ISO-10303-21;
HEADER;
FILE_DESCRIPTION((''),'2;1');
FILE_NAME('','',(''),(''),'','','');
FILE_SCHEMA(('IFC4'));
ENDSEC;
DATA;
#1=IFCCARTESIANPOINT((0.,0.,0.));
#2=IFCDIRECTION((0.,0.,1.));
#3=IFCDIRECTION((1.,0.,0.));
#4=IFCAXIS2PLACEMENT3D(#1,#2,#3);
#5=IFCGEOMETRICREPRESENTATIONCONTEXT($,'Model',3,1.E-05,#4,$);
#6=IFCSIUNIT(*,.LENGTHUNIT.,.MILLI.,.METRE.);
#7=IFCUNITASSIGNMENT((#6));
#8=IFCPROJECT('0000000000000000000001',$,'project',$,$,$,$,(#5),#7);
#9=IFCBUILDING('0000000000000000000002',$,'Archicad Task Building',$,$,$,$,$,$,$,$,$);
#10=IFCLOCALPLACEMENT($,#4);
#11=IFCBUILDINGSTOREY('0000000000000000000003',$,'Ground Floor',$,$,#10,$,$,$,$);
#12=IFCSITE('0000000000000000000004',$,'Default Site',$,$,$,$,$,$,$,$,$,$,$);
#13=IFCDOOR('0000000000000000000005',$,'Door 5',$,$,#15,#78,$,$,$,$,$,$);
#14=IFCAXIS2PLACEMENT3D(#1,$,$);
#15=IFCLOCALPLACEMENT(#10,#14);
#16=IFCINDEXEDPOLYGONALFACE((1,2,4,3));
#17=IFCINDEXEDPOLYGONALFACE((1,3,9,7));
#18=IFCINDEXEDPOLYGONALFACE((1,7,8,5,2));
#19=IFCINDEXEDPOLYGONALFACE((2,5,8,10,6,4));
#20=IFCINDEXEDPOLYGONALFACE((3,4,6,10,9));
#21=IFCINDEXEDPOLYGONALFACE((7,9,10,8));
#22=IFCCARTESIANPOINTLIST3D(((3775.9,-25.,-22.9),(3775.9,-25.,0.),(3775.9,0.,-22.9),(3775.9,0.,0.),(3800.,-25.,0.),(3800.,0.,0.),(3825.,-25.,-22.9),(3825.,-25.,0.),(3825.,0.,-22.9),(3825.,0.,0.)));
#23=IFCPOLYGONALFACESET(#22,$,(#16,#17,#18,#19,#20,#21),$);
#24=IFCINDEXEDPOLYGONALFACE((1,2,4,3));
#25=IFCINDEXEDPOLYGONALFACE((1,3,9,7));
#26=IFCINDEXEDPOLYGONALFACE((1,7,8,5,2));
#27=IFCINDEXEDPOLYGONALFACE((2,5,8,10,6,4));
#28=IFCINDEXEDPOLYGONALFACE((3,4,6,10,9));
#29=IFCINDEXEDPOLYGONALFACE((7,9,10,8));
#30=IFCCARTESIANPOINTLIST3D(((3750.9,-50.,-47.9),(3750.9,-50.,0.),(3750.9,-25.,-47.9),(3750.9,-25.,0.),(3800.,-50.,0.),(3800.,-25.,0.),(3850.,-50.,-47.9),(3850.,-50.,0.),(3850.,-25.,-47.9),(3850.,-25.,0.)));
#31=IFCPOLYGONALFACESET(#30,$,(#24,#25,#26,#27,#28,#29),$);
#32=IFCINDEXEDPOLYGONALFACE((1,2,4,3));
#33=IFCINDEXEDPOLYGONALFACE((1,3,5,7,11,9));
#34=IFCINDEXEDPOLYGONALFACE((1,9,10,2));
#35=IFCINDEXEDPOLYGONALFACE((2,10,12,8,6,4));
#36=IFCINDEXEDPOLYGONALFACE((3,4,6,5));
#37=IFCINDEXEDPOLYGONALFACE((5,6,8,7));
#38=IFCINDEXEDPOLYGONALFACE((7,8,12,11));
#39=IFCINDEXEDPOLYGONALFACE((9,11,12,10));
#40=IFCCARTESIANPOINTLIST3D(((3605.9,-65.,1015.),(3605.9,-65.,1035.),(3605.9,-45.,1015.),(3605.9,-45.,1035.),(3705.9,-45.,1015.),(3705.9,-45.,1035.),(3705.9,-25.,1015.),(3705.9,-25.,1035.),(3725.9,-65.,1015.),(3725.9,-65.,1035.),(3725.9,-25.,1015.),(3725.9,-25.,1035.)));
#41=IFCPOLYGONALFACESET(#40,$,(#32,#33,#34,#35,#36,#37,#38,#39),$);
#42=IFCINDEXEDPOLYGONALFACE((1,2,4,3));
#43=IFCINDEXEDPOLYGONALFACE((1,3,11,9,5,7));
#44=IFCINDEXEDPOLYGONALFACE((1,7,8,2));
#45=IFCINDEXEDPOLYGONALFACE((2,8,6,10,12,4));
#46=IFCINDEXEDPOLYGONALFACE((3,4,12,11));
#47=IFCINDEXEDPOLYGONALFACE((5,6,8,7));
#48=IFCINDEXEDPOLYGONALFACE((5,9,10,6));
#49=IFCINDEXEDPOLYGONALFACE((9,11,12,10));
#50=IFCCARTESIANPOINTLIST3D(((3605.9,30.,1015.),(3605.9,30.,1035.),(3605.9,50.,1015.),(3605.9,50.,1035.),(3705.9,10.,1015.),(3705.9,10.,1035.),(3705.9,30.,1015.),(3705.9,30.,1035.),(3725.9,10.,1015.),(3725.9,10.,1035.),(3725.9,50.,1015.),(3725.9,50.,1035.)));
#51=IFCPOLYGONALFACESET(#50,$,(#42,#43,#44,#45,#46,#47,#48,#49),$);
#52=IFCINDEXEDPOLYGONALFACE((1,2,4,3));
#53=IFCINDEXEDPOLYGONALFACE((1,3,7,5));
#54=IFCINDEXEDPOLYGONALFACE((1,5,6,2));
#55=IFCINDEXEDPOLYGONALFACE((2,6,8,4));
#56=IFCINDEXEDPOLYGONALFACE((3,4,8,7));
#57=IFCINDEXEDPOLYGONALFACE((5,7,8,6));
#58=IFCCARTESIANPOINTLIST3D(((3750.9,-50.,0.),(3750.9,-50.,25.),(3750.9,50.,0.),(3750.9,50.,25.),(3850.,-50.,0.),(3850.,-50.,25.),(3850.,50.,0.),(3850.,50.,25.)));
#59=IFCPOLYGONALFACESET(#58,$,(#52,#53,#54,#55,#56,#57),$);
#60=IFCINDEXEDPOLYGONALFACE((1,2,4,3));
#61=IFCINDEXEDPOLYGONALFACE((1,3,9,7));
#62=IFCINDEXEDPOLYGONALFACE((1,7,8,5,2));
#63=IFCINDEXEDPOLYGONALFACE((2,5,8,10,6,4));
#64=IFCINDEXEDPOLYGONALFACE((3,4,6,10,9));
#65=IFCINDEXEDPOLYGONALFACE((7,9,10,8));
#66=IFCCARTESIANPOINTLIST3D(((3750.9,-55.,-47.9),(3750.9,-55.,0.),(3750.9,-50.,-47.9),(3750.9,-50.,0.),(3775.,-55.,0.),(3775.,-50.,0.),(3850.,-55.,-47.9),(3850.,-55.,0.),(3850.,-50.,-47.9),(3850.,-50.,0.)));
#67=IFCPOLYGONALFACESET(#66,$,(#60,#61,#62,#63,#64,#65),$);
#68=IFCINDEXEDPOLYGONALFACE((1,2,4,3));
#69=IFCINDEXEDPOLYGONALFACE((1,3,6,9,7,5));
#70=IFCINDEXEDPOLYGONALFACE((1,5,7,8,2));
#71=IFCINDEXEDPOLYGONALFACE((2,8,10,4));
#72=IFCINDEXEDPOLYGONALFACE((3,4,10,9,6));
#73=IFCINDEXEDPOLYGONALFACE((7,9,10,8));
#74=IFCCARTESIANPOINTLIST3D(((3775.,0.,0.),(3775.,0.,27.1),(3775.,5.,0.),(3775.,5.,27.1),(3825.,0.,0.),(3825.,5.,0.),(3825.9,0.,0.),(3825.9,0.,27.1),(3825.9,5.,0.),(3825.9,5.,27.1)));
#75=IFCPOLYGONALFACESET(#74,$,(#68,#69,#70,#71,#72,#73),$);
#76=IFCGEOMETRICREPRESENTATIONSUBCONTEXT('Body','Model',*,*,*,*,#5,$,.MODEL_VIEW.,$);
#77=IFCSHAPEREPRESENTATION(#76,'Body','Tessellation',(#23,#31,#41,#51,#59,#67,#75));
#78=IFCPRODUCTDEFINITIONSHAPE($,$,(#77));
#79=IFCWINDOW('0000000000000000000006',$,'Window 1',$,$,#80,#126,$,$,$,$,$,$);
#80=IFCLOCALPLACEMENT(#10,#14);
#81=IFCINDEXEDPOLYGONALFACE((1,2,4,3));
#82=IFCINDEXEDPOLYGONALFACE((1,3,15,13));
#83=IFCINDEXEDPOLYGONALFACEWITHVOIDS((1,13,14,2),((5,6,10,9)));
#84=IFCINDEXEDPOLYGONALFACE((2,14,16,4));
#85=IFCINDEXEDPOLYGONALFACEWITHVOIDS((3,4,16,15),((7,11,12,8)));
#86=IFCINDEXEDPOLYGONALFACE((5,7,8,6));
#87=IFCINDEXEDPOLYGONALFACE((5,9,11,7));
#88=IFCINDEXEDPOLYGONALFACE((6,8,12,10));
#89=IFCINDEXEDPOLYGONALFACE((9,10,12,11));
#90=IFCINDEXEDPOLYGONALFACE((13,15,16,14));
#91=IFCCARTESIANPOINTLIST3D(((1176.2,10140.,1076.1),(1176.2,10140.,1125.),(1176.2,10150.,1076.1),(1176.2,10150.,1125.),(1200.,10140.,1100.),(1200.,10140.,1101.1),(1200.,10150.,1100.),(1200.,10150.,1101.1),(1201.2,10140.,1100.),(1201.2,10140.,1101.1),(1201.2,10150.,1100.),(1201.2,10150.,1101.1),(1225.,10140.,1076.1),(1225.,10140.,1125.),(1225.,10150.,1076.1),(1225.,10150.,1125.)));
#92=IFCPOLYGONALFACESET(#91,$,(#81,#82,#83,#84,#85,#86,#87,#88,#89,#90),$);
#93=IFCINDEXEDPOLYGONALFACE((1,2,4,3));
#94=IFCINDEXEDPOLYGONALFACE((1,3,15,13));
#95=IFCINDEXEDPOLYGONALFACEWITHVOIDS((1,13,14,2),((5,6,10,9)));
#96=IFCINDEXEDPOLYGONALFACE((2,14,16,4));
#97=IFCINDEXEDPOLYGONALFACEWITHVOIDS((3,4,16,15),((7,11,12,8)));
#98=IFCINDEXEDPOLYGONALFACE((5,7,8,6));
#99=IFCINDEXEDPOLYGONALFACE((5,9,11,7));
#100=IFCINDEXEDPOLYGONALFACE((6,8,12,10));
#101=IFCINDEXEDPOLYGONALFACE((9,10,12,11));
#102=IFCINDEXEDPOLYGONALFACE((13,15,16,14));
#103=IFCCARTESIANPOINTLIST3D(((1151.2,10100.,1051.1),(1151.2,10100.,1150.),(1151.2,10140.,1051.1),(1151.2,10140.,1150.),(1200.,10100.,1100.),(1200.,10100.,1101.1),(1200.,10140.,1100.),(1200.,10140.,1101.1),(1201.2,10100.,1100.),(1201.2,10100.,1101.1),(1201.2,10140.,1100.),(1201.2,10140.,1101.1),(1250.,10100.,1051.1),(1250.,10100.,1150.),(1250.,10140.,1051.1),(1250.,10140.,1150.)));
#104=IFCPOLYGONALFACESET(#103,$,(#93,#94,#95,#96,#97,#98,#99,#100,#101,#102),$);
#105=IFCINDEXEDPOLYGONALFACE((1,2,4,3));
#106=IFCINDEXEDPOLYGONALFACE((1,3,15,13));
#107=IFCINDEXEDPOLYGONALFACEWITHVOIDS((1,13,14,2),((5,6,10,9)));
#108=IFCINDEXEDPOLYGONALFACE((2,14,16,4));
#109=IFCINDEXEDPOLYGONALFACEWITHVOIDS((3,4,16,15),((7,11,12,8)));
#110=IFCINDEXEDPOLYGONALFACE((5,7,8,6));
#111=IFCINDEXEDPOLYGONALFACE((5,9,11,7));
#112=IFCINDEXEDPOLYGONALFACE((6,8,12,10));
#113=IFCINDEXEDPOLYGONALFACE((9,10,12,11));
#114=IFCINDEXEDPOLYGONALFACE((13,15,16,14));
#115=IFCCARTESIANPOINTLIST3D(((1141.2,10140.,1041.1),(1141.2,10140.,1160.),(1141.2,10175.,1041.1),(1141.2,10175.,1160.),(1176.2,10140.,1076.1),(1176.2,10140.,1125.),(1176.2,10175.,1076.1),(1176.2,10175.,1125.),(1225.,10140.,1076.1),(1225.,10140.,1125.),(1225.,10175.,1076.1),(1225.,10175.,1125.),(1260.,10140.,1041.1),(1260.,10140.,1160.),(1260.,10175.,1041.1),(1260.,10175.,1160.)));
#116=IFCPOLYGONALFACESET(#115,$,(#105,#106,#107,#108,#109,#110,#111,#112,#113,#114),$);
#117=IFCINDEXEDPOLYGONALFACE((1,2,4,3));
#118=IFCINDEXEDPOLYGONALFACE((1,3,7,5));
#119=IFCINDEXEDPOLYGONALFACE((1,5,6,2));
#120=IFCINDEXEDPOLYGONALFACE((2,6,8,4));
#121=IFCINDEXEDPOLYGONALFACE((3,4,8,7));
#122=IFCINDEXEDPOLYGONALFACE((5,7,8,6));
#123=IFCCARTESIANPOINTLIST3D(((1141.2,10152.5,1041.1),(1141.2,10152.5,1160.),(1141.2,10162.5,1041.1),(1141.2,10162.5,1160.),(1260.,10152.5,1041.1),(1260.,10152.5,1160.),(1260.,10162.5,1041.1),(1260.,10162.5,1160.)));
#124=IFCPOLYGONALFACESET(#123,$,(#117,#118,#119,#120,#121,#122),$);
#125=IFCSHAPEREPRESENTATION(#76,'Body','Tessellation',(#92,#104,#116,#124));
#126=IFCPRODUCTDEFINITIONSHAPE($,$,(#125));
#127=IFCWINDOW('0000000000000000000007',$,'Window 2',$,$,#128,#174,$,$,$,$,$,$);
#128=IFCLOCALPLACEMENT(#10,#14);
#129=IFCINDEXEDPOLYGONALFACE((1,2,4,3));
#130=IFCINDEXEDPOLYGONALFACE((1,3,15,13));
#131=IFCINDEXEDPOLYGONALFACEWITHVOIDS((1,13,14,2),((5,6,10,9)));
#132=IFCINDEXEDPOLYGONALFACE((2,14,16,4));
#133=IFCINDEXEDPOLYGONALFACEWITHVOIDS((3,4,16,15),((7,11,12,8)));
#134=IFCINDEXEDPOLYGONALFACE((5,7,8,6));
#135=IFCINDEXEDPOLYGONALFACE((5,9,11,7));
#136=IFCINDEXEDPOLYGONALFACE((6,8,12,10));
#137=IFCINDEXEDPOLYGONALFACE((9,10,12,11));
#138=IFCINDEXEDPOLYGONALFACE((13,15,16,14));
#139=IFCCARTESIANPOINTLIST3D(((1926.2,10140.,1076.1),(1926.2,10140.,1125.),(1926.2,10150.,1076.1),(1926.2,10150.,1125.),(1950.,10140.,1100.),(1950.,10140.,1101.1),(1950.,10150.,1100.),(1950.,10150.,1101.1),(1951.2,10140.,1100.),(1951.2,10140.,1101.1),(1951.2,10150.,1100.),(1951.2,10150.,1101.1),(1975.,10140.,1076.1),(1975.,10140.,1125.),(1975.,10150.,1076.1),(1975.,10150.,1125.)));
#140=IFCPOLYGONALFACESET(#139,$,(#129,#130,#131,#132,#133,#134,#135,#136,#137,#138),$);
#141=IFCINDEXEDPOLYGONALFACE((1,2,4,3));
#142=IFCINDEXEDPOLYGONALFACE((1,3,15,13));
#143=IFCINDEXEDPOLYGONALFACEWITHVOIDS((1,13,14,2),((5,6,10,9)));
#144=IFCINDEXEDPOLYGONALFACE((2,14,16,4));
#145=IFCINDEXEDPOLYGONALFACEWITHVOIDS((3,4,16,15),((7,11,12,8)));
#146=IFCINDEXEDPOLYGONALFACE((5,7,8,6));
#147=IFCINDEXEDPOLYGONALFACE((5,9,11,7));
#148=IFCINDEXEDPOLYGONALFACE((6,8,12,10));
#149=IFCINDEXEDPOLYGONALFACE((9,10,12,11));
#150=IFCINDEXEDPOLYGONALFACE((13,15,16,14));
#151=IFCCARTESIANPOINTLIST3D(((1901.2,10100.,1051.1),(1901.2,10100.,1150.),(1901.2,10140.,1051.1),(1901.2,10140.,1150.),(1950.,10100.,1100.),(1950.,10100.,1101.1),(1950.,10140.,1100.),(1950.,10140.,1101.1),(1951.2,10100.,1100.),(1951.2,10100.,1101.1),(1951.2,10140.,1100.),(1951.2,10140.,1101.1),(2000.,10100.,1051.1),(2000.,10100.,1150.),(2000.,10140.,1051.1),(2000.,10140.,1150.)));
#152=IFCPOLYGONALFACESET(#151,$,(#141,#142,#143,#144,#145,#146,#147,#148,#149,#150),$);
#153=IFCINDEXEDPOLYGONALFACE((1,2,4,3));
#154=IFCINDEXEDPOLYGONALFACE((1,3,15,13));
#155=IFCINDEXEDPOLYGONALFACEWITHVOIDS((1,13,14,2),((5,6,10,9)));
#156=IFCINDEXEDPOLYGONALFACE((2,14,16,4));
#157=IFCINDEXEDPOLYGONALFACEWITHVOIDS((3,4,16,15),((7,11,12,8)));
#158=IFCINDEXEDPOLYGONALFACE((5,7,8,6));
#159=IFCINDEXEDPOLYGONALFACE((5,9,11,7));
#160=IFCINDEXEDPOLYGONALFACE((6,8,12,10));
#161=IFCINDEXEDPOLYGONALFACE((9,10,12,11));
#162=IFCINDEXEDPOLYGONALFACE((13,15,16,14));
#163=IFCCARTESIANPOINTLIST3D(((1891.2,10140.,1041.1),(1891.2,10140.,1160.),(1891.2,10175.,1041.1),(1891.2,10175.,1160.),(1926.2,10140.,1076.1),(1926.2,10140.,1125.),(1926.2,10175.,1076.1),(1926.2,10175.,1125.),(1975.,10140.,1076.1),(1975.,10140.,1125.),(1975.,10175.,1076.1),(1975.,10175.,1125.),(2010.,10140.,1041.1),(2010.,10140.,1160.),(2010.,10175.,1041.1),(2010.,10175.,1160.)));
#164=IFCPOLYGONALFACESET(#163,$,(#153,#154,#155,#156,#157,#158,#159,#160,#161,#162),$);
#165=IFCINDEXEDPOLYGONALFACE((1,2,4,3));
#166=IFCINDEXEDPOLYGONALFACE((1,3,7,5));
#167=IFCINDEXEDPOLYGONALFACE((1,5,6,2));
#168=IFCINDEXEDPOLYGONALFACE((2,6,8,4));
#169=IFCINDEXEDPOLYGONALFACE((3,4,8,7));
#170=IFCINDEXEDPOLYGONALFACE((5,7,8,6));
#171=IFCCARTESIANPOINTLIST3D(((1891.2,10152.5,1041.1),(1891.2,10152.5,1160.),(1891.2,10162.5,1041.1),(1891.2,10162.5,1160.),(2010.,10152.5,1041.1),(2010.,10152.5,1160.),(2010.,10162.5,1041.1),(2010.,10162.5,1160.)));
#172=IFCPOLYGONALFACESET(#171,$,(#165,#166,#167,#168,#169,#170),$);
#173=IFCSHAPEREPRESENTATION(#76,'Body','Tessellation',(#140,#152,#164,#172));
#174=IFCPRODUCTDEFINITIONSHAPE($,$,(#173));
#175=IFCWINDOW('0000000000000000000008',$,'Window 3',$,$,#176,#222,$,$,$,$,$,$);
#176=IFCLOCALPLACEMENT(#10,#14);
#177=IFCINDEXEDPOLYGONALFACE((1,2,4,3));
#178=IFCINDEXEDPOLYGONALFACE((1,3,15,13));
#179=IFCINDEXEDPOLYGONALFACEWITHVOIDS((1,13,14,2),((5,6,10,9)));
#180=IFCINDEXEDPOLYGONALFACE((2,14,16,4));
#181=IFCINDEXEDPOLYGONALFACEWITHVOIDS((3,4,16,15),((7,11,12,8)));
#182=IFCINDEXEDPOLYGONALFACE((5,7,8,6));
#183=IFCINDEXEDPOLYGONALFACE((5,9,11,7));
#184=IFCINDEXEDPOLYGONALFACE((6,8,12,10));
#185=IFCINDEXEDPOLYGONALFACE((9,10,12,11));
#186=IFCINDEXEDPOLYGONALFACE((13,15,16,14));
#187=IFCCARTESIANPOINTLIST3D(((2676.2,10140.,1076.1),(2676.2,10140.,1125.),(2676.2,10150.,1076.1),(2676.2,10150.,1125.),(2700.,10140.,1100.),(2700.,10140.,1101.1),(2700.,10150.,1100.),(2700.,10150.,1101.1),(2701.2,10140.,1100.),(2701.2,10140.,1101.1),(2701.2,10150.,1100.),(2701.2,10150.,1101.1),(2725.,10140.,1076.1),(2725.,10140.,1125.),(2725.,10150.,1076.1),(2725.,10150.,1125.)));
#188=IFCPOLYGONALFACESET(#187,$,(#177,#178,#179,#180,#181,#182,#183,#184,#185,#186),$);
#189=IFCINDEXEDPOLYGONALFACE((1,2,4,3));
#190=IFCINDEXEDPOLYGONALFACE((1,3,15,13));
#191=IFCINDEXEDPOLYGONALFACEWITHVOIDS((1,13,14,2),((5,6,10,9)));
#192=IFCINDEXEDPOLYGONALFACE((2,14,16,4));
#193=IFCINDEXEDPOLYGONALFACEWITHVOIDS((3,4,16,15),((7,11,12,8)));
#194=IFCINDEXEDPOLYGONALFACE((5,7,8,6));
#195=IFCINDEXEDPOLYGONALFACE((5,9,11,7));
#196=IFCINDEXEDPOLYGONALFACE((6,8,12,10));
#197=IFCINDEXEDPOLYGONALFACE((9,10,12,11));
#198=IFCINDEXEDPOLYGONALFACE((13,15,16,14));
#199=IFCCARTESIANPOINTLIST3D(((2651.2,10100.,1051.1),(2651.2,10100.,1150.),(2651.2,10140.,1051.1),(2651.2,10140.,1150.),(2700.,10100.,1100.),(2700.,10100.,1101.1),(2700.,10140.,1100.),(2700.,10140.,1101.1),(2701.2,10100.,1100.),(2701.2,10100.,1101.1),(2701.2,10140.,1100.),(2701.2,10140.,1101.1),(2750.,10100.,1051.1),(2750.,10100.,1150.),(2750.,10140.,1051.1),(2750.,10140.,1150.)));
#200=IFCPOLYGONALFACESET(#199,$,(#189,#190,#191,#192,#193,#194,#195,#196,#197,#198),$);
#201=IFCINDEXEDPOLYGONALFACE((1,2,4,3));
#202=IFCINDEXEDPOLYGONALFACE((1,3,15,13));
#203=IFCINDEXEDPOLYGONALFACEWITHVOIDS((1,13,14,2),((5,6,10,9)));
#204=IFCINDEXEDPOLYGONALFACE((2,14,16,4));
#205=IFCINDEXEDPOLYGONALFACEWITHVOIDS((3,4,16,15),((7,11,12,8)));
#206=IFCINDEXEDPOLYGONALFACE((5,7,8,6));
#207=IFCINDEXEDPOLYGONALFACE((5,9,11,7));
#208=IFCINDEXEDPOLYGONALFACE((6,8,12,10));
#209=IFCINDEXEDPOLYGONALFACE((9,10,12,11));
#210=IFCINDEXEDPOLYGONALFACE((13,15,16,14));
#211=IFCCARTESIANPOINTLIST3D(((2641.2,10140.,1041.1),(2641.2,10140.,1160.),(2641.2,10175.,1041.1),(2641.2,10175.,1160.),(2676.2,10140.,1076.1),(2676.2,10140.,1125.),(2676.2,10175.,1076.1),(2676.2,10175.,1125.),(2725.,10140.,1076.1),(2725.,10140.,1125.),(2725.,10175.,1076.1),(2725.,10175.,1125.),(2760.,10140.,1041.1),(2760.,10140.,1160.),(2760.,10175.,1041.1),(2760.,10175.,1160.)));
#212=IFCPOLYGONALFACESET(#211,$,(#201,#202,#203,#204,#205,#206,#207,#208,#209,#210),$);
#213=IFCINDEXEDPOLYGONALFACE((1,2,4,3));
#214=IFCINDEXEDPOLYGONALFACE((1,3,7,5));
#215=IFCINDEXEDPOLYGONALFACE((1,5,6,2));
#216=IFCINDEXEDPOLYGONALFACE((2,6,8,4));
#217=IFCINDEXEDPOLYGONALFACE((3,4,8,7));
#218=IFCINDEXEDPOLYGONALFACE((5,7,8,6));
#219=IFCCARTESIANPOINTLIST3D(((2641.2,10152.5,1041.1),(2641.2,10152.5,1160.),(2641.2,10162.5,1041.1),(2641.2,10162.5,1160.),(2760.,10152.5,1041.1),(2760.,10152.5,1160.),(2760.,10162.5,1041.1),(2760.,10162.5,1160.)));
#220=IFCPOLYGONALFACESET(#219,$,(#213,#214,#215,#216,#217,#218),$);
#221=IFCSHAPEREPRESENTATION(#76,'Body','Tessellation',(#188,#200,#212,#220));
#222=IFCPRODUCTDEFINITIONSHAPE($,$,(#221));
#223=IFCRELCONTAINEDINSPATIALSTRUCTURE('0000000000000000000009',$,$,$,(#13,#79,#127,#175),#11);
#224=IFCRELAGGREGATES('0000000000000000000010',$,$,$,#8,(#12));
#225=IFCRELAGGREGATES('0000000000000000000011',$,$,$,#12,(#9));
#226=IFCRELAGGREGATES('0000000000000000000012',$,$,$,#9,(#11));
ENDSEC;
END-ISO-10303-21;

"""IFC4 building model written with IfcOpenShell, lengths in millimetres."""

from ifc_helpers import new_model, si_unit, frame, origin_with_axes, place, context, subcontext, project, spatial, line, indexed_curve, outline, extrude, element, save


model = new_model("IFC4")

# Units and contexts
model_context = context("Model", 3, precision=1e-05, world=origin_with_axes())
body_context = subcontext(model_context, "Body", "Model", "MODEL_VIEW")
ifc_project = project(units=[si_unit("LENGTHUNIT", "METRE", prefix="MILLI")], contexts=[model_context])

# Site, building, storey
site = spatial("IfcSite", under=ifc_project, Name="Default Site")
building = spatial("IfcBuilding", under=site, Name="Archicad Task Building")
storey_placement = place(None, origin_with_axes())
storey = spatial("IfcBuildingStorey", under=building, at=storey_placement, Name="Ground Floor")

# Door
door_1_placement = place(storey_placement, frame((3800.0, -50.0, 0.0), z_axis=(0.0, 0.0, 1.0), x_axis=(1.0, 0.0, 0.0)))
element("IfcDoor", 1, at=door_1_placement, inside=storey, Name="Door 5", context=body_context, shape_type="SweptSolid", body=[
    extrude(outline(indexed_curve([(0.0, 0.0), (0.0, 2.1), (0.9, 2.1), (0.9, 0.0), (-24.1, 0.0), (-24.1, -22.9), (25.0, -22.9), (25.0, 0.0)], segments=[line(1, 2, 3, 4, 5, 6, 7, 8, 1)])), frame((0.0, 25.0, 0.0), z_axis=(0.0, -1.0, 0.0), x_axis=(1.0, 0.0, 0.0)), (0.0, 0.0, -1.0), 25.0),
    extrude(outline(indexed_curve([(0.0, 0.0), (0.0, 2.1), (0.9, 2.1), (0.9, 0.0), (-49.1, 0.0), (-49.1, -47.9), (50.0, -47.9), (50.0, 0.0)], segments=[line(1, 2, 3, 4, 5, 6, 7, 8, 1)])), frame((0.0, 0.0, 0.0), z_axis=(0.0, -1.0, 0.0), x_axis=(1.0, 0.0, 0.0)), (0.0, 0.0, -1.0), 25.0),
    extrude(outline(indexed_curve([(0.0, 0.0), (-49.1, 0.0), (-49.1, 35.0), (0.0, 35.0)], segments=[line(1, 2, 3, 4, 1)])), frame((25.0, 25.0, 25.0), z_axis=(0.0, 0.0, 1.0), x_axis=(1.0, 0.0, 0.0)), (0.0, 0.0, 1.0), -47.9),
    extrude(outline(indexed_curve([(0.0, 0.0), (0.0, -40.0), (-120.0, -40.0), (-120.0, -20.0), (-20.0, -20.0), (-20.0, 0.0)], segments=[line(1, 2, 3, 4, 5, 6, 1)])), frame((-74.1, 25.0, 1015.0), z_axis=(0.0, 0.0, 1.0), x_axis=(1.0, 0.0, 0.0)), (0.0, 0.0, 1.0), 20.0),
    extrude(outline(indexed_curve([(0.0, 0.0), (0.0, 40.0), (-120.0, 40.0), (-120.0, 20.0), (-20.0, 20.0), (-20.0, 0.0)], segments=[line(1, 2, 3, 4, 5, 6, 1)])), frame((-74.1, 60.0, 1015.0), z_axis=(0.0, 0.0, 1.0), x_axis=(1.0, 0.0, 0.0)), (0.0, 0.0, 1.0), 20.0),
    extrude(outline(indexed_curve([(0.0, 0.0), (-99.1, 0.0), (-99.1, 100.0), (0.0, 100.0)], segments=[line(1, 2, 3, 4, 1)])), frame((50.0, 0.0, 0.0), z_axis=(0.0, 0.0, 1.0), x_axis=(1.0, 0.0, 0.0)), (0.0, 0.0, 1.0), 25.0),
    extrude(outline(indexed_curve([(0.0, 0.0), (0.0, 27.1), (50.9, 27.1), (50.9, 0.0), (-24.1, 0.0), (-24.1, -47.9), (75.0, -47.9), (75.0, 0.0)], segments=[line(1, 2, 3, 4, 5, 6, 7, 8, 1)])), frame((-25.0, -5.0, 0.0), z_axis=(0.0, -1.0, 0.0), x_axis=(1.0, 0.0, 0.0)), (0.0, 0.0, -1.0), 5.0),
    extrude(outline(indexed_curve([(0.0, 0.0), (0.0, 27.1), (50.9, 27.1), (50.9, 0.0), (0.9, 0.0), (0.9, -22.9), (50.0, -22.9), (50.0, 0.0)], segments=[line(1, 2, 3, 4, 5, 6, 7, 8, 1)])), frame((-25.0, 50.0, 0.0), z_axis=(0.0, -1.0, 0.0), x_axis=(1.0, 0.0, 0.0)), (0.0, 0.0, -1.0), 5.0),
])

# Windows
for number, where, z_axis, x_axis, name in (
    (2, (1200.0, 10050.0, 1100.0), (0.0, 0.0, 1.0), (1.0, 0.0, 0.0), "Window 1"),
    (3, (1950.0, 10050.0, 1100.0), (0.0, 0.0, 1.0), (1.0, 0.0, 0.0), "Window 2"),
    (4, (2700.0, 10050.0, 1100.0), (0.0, 0.0, 1.0), (1.0, 0.0, 0.0), "Window 3"),
):
    element("IfcWindow", number, at=place(storey_placement, frame(where, z_axis=z_axis, x_axis=x_axis)), inside=storey, Name=name, context=body_context, shape_type="SweptSolid", body=[
        extrude(outline(indexed_curve([(0.0, 0.0), (1.2, 0.0), (1.2, 1.1), (0.0, 1.1)], segments=[line(1, 2, 3, 4, 1)]), holes=[indexed_curve([(25.0, 25.0), (-23.8, 25.0), (-23.8, -23.9), (25.0, -23.9)], segments=[line(1, 2, 3, 4, 1)])]), frame((0.0, 90.0, 0.0), z_axis=(0.0, -1.0, 0.0), x_axis=(1.0, 0.0, 0.0)), (0.0, 0.0, -1.0), 10.0),
        extrude(outline(indexed_curve([(0.0, 0.0), (1.2, 0.0), (1.2, 1.1), (0.0, 1.1)], segments=[line(1, 2, 3, 4, 1)]), holes=[indexed_curve([(50.0, 50.0), (-48.8, 50.0), (-48.8, -48.9), (50.0, -48.9)], segments=[line(1, 2, 3, 4, 1)])]), frame((0.0, 50.0, 0.0), z_axis=(0.0, -1.0, 0.0), x_axis=(1.0, 0.0, 0.0)), (0.0, 0.0, -1.0), 40.0),
        extrude(outline(indexed_curve([(0.0, 0.0), (-48.8, 0.0), (-48.8, -48.9), (0.0, -48.9)], segments=[line(1, 2, 3, 4, 1)]), holes=[indexed_curve([(35.0, 35.0), (-83.8, 35.0), (-83.8, -83.9), (35.0, -83.9)], segments=[line(1, 2, 3, 4, 1)])]), frame((25.0, 90.0, 25.0), z_axis=(0.0, -1.0, 0.0), x_axis=(1.0, 0.0, 0.0)), (0.0, 0.0, -1.0), 35.0),
        extrude(outline(indexed_curve([(35.0, 35.0), (-83.8, 35.0), (-83.8, -83.9), (35.0, -83.9)], segments=[line(1, 2, 3, 4, 1)])), frame((25.0, 102.5, 25.0), z_axis=(0.0, -1.0, 0.0), x_axis=(1.0, 0.0, 0.0)), (0.0, 0.0, -1.0), 10.0),
    ])

save(model, "model.ifc")
